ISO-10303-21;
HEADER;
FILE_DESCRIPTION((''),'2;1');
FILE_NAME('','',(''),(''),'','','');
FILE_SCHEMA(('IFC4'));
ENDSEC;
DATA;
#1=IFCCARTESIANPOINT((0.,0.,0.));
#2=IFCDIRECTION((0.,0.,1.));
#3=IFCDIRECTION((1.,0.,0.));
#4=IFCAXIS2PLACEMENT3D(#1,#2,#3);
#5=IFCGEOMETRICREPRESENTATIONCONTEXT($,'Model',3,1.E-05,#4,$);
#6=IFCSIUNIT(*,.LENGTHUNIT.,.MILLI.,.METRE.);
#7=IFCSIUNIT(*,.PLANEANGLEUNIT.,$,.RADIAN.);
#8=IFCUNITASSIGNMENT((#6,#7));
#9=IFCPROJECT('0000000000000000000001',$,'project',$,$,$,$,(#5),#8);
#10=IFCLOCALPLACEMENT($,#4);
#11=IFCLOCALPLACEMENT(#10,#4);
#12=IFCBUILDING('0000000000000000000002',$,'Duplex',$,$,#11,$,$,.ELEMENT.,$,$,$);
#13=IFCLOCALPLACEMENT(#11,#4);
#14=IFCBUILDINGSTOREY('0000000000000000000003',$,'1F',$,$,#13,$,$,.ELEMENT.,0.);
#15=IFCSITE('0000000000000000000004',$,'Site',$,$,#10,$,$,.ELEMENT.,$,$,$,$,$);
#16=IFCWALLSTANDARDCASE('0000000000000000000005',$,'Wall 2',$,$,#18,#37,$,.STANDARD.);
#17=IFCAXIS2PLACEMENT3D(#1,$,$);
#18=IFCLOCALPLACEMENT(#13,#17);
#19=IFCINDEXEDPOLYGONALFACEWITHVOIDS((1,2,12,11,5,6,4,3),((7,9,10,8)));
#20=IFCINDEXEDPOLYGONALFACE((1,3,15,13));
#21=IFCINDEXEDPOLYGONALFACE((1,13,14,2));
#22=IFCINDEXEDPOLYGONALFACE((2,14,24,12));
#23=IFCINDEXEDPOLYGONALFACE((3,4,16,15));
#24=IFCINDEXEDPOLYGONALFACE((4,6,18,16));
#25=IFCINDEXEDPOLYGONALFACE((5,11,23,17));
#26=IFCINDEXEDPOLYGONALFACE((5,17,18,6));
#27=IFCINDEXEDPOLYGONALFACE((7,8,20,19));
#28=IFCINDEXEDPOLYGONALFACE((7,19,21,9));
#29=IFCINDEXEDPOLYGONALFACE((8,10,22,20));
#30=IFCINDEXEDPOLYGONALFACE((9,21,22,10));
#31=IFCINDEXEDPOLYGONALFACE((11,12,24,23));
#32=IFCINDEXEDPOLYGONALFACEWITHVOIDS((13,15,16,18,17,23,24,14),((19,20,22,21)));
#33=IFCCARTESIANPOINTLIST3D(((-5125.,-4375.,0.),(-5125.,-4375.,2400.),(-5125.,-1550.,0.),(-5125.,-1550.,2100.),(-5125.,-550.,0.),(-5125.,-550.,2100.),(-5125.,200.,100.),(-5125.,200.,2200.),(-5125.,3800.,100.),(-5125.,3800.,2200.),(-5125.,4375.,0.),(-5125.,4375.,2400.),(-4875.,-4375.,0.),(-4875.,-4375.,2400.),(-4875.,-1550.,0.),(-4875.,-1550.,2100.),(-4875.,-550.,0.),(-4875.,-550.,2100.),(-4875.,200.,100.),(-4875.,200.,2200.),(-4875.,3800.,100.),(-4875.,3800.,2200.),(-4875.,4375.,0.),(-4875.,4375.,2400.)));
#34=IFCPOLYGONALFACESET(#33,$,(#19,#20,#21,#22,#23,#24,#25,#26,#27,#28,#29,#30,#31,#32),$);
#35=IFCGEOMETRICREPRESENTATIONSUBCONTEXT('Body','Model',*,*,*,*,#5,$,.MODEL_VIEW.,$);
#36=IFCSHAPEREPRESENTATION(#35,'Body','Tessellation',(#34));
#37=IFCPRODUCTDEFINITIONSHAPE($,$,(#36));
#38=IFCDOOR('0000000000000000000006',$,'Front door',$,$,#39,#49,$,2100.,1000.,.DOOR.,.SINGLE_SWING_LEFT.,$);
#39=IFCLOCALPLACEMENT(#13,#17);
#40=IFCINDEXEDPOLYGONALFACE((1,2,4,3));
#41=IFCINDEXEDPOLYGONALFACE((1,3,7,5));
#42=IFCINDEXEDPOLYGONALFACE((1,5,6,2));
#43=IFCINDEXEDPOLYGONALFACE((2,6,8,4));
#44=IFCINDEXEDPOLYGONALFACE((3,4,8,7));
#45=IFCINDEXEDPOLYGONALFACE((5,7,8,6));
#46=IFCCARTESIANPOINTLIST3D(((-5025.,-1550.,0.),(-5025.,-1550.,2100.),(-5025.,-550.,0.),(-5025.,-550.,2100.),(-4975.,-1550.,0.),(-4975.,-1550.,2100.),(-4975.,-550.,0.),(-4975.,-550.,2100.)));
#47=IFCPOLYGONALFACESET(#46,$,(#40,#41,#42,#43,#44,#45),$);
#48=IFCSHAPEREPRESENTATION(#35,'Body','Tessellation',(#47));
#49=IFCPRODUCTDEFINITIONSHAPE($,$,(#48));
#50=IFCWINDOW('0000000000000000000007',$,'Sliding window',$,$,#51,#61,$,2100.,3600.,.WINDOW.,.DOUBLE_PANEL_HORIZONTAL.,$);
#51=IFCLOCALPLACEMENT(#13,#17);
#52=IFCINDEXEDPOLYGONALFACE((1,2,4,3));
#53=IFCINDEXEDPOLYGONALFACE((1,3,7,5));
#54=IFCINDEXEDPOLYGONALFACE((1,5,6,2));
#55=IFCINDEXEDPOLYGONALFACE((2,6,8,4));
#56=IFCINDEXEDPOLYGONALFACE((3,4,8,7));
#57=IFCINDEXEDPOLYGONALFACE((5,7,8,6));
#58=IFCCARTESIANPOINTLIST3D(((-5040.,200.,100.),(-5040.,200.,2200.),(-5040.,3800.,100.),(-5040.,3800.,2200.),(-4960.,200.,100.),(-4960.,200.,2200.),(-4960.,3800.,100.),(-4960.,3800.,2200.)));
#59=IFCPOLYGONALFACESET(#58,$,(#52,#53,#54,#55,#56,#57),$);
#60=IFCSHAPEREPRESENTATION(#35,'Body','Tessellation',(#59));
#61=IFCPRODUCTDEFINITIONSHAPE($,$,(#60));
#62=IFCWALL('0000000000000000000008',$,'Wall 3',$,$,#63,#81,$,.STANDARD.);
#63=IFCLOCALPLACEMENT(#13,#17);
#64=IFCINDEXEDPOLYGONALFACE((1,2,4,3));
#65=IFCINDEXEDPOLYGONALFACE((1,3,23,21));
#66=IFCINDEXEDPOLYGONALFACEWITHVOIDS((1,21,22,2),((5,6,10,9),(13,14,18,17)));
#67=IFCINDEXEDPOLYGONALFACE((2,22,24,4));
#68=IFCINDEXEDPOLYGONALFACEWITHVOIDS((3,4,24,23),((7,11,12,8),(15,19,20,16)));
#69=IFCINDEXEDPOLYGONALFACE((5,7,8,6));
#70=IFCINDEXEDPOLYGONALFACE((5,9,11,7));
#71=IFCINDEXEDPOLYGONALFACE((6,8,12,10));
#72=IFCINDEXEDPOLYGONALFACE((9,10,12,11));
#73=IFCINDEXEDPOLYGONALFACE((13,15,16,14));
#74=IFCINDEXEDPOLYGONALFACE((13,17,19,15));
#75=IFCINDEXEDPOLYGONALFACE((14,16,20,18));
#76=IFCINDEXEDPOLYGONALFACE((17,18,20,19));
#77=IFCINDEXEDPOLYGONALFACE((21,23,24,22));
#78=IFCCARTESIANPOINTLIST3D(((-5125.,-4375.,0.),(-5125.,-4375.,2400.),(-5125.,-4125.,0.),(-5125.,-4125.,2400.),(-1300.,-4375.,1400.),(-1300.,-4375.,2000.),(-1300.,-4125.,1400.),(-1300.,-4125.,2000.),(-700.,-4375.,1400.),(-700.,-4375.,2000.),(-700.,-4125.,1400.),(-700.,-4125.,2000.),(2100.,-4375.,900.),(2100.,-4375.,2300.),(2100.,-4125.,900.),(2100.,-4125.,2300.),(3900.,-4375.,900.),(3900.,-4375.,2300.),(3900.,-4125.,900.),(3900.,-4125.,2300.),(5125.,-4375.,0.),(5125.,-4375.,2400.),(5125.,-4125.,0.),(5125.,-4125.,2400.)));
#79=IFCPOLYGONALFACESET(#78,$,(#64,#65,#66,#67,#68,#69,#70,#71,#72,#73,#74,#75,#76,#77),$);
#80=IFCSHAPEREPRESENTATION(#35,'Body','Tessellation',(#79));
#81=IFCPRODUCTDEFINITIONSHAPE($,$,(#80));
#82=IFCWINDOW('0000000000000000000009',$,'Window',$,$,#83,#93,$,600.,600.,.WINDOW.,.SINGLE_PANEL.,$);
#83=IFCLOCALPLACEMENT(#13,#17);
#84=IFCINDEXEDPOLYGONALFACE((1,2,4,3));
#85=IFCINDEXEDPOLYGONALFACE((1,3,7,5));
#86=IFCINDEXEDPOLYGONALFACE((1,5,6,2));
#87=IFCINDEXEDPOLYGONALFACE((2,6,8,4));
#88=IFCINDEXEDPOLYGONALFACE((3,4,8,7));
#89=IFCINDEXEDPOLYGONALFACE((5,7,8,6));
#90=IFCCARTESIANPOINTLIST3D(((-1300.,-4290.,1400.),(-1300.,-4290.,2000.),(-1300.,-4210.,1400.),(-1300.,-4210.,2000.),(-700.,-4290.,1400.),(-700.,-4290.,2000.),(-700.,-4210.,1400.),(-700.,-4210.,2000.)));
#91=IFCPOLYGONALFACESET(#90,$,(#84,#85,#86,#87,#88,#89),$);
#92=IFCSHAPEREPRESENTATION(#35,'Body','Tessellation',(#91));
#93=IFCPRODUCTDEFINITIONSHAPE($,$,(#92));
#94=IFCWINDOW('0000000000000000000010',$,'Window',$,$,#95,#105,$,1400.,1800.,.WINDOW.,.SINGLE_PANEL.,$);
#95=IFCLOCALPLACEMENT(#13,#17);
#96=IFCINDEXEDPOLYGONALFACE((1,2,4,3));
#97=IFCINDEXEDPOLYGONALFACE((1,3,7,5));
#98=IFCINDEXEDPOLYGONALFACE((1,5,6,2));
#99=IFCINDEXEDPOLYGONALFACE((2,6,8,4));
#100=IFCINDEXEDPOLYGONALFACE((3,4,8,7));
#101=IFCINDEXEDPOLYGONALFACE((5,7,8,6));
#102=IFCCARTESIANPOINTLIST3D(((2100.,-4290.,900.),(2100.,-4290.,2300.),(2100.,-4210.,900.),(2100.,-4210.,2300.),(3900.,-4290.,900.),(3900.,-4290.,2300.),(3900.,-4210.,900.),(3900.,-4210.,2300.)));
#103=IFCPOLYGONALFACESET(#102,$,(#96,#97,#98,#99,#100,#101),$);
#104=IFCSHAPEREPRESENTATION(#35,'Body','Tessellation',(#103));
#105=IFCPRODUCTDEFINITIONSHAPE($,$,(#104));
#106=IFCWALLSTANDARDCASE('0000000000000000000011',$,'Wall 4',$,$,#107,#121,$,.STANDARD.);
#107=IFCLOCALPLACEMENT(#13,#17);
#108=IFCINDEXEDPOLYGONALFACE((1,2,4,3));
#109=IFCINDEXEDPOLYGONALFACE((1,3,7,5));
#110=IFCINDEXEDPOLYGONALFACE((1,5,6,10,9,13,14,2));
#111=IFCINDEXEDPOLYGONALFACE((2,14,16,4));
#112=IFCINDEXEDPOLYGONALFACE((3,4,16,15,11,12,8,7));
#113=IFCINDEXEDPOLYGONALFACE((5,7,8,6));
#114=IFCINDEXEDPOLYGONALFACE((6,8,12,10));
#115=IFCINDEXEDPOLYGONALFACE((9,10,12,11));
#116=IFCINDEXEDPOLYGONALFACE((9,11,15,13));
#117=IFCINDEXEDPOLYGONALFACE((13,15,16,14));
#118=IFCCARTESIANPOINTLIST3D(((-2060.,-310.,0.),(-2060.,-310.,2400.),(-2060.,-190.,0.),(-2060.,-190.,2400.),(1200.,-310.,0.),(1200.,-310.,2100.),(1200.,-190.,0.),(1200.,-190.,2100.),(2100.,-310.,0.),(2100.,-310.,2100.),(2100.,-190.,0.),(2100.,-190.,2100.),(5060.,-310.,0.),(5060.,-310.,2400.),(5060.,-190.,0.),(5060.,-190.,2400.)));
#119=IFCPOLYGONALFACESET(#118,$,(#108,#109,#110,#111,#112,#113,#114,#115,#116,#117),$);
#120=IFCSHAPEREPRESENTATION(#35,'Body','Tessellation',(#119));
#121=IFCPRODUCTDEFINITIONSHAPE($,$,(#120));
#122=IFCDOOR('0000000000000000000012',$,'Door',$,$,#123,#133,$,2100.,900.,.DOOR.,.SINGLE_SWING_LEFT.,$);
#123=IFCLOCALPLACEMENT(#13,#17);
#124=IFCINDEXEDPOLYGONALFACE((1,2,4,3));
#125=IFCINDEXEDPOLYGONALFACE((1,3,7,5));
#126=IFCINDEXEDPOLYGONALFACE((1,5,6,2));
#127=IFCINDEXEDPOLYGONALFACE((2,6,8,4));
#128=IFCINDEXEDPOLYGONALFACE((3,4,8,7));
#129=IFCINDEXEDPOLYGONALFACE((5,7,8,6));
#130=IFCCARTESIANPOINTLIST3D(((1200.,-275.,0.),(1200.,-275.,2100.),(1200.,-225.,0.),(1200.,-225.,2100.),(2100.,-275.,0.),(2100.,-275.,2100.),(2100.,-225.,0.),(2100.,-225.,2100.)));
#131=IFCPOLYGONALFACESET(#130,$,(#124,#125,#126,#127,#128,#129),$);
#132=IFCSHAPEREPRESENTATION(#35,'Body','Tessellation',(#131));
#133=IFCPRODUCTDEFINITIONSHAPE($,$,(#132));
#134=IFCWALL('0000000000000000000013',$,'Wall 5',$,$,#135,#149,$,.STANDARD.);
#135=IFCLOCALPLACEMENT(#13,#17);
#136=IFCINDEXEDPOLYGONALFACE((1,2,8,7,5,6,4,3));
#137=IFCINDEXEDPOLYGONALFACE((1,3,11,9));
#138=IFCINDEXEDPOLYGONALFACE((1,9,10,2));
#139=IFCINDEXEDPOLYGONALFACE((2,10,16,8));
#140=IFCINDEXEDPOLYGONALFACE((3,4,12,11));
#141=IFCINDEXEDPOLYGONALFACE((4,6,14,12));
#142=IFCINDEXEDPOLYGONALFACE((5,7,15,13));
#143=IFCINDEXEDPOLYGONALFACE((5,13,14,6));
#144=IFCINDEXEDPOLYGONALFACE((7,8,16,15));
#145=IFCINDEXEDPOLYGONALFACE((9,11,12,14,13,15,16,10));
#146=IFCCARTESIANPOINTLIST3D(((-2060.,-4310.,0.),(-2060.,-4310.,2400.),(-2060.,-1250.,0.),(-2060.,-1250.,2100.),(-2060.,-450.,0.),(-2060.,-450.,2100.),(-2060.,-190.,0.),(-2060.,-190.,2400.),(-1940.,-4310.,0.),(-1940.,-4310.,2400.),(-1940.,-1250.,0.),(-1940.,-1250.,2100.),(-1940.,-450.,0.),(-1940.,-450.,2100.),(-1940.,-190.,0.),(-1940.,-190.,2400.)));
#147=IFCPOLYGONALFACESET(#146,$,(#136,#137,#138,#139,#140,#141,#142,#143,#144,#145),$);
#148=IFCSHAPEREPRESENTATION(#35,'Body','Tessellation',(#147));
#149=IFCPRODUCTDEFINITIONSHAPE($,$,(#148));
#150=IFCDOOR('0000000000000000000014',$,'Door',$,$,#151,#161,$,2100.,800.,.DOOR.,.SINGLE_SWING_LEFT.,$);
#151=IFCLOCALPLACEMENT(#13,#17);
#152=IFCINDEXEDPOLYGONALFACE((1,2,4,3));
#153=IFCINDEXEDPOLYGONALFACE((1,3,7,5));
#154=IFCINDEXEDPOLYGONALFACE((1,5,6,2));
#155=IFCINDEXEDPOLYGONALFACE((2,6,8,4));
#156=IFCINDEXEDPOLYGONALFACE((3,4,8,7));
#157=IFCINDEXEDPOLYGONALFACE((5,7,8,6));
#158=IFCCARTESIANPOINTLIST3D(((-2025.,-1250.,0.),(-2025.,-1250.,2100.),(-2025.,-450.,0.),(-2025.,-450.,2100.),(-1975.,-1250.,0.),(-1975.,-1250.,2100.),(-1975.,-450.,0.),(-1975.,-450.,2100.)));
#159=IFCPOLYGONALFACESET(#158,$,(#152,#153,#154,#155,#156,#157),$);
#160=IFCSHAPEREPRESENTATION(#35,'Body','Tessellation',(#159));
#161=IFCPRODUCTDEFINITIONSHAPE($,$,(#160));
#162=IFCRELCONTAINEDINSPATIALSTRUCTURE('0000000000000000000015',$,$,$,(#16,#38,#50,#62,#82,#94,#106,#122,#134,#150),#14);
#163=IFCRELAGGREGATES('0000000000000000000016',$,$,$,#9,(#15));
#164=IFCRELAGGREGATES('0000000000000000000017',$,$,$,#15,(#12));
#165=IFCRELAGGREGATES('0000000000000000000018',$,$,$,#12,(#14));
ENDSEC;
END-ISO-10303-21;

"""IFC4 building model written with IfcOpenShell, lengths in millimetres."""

from ifc_helpers import new_model, si_unit, frame, frame_2d, origin, origin_with_axes, place, context, subcontext, project, spatial, rectangle, extrude, element, fill, save


model = new_model("IFC4")

# Units and contexts
model_context = context("Model", 3, precision=1e-05, world=origin_with_axes())
body_context = subcontext(model_context, "Body", "Model", "MODEL_VIEW")
ifc_project = project(units=[si_unit("LENGTHUNIT", "METRE", prefix="MILLI"), si_unit("PLANEANGLEUNIT", "RADIAN")], contexts=[model_context])

# Site, building, storey
site_placement = place(None, origin_with_axes())
site = spatial("IfcSite", under=ifc_project, at=site_placement, Name="Site", CompositionType="ELEMENT")
building_placement = place(site_placement, origin_with_axes())
building = spatial("IfcBuilding", under=site, at=building_placement, Name="Duplex", CompositionType="ELEMENT")
storey_placement = place(building_placement, origin_with_axes())
storey = spatial("IfcBuildingStorey", under=building, at=storey_placement, Name="1F", CompositionType="ELEMENT", Elevation=0.0)

# Wall, openings, door, window
wall_1_placement = place(storey_placement, frame((-5000.0, 4250.0, 0.0), z_axis=(0.0, 0.0, 1.0), x_axis=(0.0, -1.0, 0.0)))
wall_1 = element("IfcWallStandardCase", 1, at=wall_1_placement, inside=storey, Name="Wall 2", PredefinedType="STANDARD", context=body_context, shape_type="SweptSolid", body=[
    extrude(rectangle(XDim=8750.0, YDim=250.0, at=frame_2d((4250.0, 0.0))), origin(), (0.0, 0.0, 1.0), 2400.0),
])
opening_1_placement = place(wall_1_placement, frame((4800.0, 0.0, 0.0), z_axis=(0.0, 0.0, 1.0), x_axis=(1.0, 0.0, 0.0)))
opening_1 = element("IfcOpeningElement", 2, at=opening_1_placement, cuts=wall_1, PredefinedType="OPENING", context=body_context, shape_type="SweptSolid", body=[
    extrude(rectangle(XDim=1000.0, YDim=350.0, at=frame_2d((500.0, 0.0))), origin(), (0.0, 0.0, 1.0), 2100.0),
])
opening_2_placement = place(wall_1_placement, frame((450.0, 0.0, 100.0), z_axis=(0.0, 0.0, 1.0), x_axis=(1.0, 0.0, 0.0)))
opening_2 = element("IfcOpeningElement", 3, at=opening_2_placement, cuts=wall_1, PredefinedType="OPENING", context=body_context, shape_type="SweptSolid", body=[
    extrude(rectangle(XDim=3600.0, YDim=350.0, at=frame_2d((1800.0, 0.0))), origin(), (0.0, 0.0, 1.0), 2100.0),
])
door_1_placement = place(opening_1_placement, origin_with_axes())
door_1 = element("IfcDoor", 4, at=door_1_placement, inside=storey, Name="Front door", OperationType="SINGLE_SWING_LEFT", OverallHeight=2100.0, OverallWidth=1000.0, PredefinedType="DOOR", context=body_context, shape_type="SweptSolid", body=[
    extrude(rectangle(XDim=1000.0, YDim=50.0, at=frame_2d((500.0, 0.0))), origin(), (0.0, 0.0, 1.0), 2100.0),
])
fill(opening_1, door_1)
window_1_placement = place(opening_2_placement, origin_with_axes())
window_1 = element("IfcWindow", 5, at=window_1_placement, inside=storey, Name="Sliding window", OverallHeight=2100.0, OverallWidth=3600.0, PartitioningType="DOUBLE_PANEL_HORIZONTAL", PredefinedType="WINDOW", context=body_context, shape_type="SweptSolid", body=[
    extrude(rectangle(XDim=3600.0, YDim=80.0, at=frame_2d((1800.0, 0.0))), origin(), (0.0, 0.0, 1.0), 2100.0),
])
fill(opening_2, window_1)

# Wall, openings, windows
wall_2_placement = place(storey_placement, frame((-5000.0, -4250.0, 0.0), z_axis=(0.0, 0.0, 1.0), x_axis=(1.0, 0.0, 0.0)))
wall_2 = element("IfcWall", 6, at=wall_2_placement, inside=storey, Name="Wall 3", PredefinedType="STANDARD", context=body_context, shape_type="SweptSolid", body=[
    extrude(rectangle(XDim=10250.0, YDim=250.0, at=frame_2d((5000.0, 0.0))), origin(), (0.0, 0.0, 1.0), 2400.0),
])
opening_3_placement = place(wall_2_placement, frame((3700.0, 0.0, 1400.0), z_axis=(0.0, 0.0, 1.0), x_axis=(1.0, 0.0, 0.0)))
opening_3 = element("IfcOpeningElement", 7, at=opening_3_placement, cuts=wall_2, PredefinedType="OPENING", context=body_context, shape_type="SweptSolid", body=[
    extrude(rectangle(XDim=600.0, YDim=350.0, at=frame_2d((300.0, 0.0))), origin(), (0.0, 0.0, 1.0), 600.0),
])
opening_4_placement = place(wall_2_placement, frame((7100.0, 0.0, 900.0), z_axis=(0.0, 0.0, 1.0), x_axis=(1.0, 0.0, 0.0)))
opening_4 = element("IfcOpeningElement", 8, at=opening_4_placement, cuts=wall_2, PredefinedType="OPENING", context=body_context, shape_type="SweptSolid", body=[
    extrude(rectangle(XDim=1800.0, YDim=350.0, at=frame_2d((900.0, 0.0))), origin(), (0.0, 0.0, 1.0), 1400.0),
])
window_2_placement = place(opening_3_placement, origin_with_axes())
window_2 = element("IfcWindow", 9, at=window_2_placement, inside=storey, Name="Window", OverallHeight=600.0, OverallWidth=600.0, PartitioningType="SINGLE_PANEL", PredefinedType="WINDOW", context=body_context, shape_type="SweptSolid", body=[
    extrude(rectangle(XDim=600.0, YDim=80.0, at=frame_2d((300.0, 0.0))), origin(), (0.0, 0.0, 1.0), 600.0),
])
fill(opening_3, window_2)
window_3_placement = place(opening_4_placement, origin_with_axes())
window_3 = element("IfcWindow", 10, at=window_3_placement, inside=storey, Name="Window", OverallHeight=1400.0, OverallWidth=1800.0, PartitioningType="SINGLE_PANEL", PredefinedType="WINDOW", context=body_context, shape_type="SweptSolid", body=[
    extrude(rectangle(XDim=1800.0, YDim=80.0, at=frame_2d((900.0, 0.0))), origin(), (0.0, 0.0, 1.0), 1400.0),
])
fill(opening_4, window_3)

# Walls, openings, doors
wall_3_placement = place(storey_placement, frame((-2000.0, -250.0, 0.0), z_axis=(0.0, 0.0, 1.0), x_axis=(1.0, 0.0, 0.0)))
wall_3 = element("IfcWallStandardCase", 11, at=wall_3_placement, inside=storey, Name="Wall 4", PredefinedType="STANDARD", context=body_context, shape_type="SweptSolid", body=[
    extrude(rectangle(XDim=7120.0, YDim=120.0, at=frame_2d((3500.0, 0.0))), origin(), (0.0, 0.0, 1.0), 2400.0),
])
opening_5_placement = place(wall_3_placement, frame((3200.0, 0.0, 0.0), z_axis=(0.0, 0.0, 1.0), x_axis=(1.0, 0.0, 0.0)))
opening_5 = element("IfcOpeningElement", 12, at=opening_5_placement, cuts=wall_3, PredefinedType="OPENING", context=body_context, shape_type="SweptSolid", body=[
    extrude(rectangle(XDim=900.0, YDim=220.0, at=frame_2d((450.0, 0.0))), origin(), (0.0, 0.0, 1.0), 2100.0),
])
door_2_placement = place(opening_5_placement, origin_with_axes())
door_2 = element("IfcDoor", 13, at=door_2_placement, inside=storey, Name="Door", OperationType="SINGLE_SWING_LEFT", OverallHeight=2100.0, OverallWidth=900.0, PredefinedType="DOOR", context=body_context, shape_type="SweptSolid", body=[
    extrude(rectangle(XDim=900.0, YDim=50.0, at=frame_2d((450.0, 0.0))), origin(), (0.0, 0.0, 1.0), 2100.0),
])
fill(opening_5, door_2)
wall_4_placement = place(storey_placement, frame((-2000.0, -250.0, 0.0), z_axis=(0.0, 0.0, 1.0), x_axis=(0.0, -1.0, 0.0)))
wall_4 = element("IfcWall", 14, at=wall_4_placement, inside=storey, Name="Wall 5", PredefinedType="STANDARD", context=body_context, shape_type="SweptSolid", body=[
    extrude(rectangle(XDim=4120.0, YDim=120.0, at=frame_2d((2000.0, 0.0))), origin(), (0.0, 0.0, 1.0), 2400.0),
])
opening_6_placement = place(wall_4_placement, frame((200.0, 0.0, 0.0), z_axis=(0.0, 0.0, 1.0), x_axis=(1.0, 0.0, 0.0)))
opening_6 = element("IfcOpeningElement", 15, at=opening_6_placement, cuts=wall_4, PredefinedType="OPENING", context=body_context, shape_type="SweptSolid", body=[
    extrude(rectangle(XDim=800.0, YDim=220.0, at=frame_2d((400.0, 0.0))), origin(), (0.0, 0.0, 1.0), 2100.0),
])
door_3_placement = place(opening_6_placement, origin_with_axes())
door_3 = element("IfcDoor", 16, at=door_3_placement, inside=storey, Name="Door", OperationType="SINGLE_SWING_LEFT", OverallHeight=2100.0, OverallWidth=800.0, PredefinedType="DOOR", context=body_context, shape_type="SweptSolid", body=[
    extrude(rectangle(XDim=800.0, YDim=50.0, at=frame_2d((400.0, 0.0))), origin(), (0.0, 0.0, 1.0), 2100.0),
])
fill(opening_6, door_3)

save(model, "model.ifc")
